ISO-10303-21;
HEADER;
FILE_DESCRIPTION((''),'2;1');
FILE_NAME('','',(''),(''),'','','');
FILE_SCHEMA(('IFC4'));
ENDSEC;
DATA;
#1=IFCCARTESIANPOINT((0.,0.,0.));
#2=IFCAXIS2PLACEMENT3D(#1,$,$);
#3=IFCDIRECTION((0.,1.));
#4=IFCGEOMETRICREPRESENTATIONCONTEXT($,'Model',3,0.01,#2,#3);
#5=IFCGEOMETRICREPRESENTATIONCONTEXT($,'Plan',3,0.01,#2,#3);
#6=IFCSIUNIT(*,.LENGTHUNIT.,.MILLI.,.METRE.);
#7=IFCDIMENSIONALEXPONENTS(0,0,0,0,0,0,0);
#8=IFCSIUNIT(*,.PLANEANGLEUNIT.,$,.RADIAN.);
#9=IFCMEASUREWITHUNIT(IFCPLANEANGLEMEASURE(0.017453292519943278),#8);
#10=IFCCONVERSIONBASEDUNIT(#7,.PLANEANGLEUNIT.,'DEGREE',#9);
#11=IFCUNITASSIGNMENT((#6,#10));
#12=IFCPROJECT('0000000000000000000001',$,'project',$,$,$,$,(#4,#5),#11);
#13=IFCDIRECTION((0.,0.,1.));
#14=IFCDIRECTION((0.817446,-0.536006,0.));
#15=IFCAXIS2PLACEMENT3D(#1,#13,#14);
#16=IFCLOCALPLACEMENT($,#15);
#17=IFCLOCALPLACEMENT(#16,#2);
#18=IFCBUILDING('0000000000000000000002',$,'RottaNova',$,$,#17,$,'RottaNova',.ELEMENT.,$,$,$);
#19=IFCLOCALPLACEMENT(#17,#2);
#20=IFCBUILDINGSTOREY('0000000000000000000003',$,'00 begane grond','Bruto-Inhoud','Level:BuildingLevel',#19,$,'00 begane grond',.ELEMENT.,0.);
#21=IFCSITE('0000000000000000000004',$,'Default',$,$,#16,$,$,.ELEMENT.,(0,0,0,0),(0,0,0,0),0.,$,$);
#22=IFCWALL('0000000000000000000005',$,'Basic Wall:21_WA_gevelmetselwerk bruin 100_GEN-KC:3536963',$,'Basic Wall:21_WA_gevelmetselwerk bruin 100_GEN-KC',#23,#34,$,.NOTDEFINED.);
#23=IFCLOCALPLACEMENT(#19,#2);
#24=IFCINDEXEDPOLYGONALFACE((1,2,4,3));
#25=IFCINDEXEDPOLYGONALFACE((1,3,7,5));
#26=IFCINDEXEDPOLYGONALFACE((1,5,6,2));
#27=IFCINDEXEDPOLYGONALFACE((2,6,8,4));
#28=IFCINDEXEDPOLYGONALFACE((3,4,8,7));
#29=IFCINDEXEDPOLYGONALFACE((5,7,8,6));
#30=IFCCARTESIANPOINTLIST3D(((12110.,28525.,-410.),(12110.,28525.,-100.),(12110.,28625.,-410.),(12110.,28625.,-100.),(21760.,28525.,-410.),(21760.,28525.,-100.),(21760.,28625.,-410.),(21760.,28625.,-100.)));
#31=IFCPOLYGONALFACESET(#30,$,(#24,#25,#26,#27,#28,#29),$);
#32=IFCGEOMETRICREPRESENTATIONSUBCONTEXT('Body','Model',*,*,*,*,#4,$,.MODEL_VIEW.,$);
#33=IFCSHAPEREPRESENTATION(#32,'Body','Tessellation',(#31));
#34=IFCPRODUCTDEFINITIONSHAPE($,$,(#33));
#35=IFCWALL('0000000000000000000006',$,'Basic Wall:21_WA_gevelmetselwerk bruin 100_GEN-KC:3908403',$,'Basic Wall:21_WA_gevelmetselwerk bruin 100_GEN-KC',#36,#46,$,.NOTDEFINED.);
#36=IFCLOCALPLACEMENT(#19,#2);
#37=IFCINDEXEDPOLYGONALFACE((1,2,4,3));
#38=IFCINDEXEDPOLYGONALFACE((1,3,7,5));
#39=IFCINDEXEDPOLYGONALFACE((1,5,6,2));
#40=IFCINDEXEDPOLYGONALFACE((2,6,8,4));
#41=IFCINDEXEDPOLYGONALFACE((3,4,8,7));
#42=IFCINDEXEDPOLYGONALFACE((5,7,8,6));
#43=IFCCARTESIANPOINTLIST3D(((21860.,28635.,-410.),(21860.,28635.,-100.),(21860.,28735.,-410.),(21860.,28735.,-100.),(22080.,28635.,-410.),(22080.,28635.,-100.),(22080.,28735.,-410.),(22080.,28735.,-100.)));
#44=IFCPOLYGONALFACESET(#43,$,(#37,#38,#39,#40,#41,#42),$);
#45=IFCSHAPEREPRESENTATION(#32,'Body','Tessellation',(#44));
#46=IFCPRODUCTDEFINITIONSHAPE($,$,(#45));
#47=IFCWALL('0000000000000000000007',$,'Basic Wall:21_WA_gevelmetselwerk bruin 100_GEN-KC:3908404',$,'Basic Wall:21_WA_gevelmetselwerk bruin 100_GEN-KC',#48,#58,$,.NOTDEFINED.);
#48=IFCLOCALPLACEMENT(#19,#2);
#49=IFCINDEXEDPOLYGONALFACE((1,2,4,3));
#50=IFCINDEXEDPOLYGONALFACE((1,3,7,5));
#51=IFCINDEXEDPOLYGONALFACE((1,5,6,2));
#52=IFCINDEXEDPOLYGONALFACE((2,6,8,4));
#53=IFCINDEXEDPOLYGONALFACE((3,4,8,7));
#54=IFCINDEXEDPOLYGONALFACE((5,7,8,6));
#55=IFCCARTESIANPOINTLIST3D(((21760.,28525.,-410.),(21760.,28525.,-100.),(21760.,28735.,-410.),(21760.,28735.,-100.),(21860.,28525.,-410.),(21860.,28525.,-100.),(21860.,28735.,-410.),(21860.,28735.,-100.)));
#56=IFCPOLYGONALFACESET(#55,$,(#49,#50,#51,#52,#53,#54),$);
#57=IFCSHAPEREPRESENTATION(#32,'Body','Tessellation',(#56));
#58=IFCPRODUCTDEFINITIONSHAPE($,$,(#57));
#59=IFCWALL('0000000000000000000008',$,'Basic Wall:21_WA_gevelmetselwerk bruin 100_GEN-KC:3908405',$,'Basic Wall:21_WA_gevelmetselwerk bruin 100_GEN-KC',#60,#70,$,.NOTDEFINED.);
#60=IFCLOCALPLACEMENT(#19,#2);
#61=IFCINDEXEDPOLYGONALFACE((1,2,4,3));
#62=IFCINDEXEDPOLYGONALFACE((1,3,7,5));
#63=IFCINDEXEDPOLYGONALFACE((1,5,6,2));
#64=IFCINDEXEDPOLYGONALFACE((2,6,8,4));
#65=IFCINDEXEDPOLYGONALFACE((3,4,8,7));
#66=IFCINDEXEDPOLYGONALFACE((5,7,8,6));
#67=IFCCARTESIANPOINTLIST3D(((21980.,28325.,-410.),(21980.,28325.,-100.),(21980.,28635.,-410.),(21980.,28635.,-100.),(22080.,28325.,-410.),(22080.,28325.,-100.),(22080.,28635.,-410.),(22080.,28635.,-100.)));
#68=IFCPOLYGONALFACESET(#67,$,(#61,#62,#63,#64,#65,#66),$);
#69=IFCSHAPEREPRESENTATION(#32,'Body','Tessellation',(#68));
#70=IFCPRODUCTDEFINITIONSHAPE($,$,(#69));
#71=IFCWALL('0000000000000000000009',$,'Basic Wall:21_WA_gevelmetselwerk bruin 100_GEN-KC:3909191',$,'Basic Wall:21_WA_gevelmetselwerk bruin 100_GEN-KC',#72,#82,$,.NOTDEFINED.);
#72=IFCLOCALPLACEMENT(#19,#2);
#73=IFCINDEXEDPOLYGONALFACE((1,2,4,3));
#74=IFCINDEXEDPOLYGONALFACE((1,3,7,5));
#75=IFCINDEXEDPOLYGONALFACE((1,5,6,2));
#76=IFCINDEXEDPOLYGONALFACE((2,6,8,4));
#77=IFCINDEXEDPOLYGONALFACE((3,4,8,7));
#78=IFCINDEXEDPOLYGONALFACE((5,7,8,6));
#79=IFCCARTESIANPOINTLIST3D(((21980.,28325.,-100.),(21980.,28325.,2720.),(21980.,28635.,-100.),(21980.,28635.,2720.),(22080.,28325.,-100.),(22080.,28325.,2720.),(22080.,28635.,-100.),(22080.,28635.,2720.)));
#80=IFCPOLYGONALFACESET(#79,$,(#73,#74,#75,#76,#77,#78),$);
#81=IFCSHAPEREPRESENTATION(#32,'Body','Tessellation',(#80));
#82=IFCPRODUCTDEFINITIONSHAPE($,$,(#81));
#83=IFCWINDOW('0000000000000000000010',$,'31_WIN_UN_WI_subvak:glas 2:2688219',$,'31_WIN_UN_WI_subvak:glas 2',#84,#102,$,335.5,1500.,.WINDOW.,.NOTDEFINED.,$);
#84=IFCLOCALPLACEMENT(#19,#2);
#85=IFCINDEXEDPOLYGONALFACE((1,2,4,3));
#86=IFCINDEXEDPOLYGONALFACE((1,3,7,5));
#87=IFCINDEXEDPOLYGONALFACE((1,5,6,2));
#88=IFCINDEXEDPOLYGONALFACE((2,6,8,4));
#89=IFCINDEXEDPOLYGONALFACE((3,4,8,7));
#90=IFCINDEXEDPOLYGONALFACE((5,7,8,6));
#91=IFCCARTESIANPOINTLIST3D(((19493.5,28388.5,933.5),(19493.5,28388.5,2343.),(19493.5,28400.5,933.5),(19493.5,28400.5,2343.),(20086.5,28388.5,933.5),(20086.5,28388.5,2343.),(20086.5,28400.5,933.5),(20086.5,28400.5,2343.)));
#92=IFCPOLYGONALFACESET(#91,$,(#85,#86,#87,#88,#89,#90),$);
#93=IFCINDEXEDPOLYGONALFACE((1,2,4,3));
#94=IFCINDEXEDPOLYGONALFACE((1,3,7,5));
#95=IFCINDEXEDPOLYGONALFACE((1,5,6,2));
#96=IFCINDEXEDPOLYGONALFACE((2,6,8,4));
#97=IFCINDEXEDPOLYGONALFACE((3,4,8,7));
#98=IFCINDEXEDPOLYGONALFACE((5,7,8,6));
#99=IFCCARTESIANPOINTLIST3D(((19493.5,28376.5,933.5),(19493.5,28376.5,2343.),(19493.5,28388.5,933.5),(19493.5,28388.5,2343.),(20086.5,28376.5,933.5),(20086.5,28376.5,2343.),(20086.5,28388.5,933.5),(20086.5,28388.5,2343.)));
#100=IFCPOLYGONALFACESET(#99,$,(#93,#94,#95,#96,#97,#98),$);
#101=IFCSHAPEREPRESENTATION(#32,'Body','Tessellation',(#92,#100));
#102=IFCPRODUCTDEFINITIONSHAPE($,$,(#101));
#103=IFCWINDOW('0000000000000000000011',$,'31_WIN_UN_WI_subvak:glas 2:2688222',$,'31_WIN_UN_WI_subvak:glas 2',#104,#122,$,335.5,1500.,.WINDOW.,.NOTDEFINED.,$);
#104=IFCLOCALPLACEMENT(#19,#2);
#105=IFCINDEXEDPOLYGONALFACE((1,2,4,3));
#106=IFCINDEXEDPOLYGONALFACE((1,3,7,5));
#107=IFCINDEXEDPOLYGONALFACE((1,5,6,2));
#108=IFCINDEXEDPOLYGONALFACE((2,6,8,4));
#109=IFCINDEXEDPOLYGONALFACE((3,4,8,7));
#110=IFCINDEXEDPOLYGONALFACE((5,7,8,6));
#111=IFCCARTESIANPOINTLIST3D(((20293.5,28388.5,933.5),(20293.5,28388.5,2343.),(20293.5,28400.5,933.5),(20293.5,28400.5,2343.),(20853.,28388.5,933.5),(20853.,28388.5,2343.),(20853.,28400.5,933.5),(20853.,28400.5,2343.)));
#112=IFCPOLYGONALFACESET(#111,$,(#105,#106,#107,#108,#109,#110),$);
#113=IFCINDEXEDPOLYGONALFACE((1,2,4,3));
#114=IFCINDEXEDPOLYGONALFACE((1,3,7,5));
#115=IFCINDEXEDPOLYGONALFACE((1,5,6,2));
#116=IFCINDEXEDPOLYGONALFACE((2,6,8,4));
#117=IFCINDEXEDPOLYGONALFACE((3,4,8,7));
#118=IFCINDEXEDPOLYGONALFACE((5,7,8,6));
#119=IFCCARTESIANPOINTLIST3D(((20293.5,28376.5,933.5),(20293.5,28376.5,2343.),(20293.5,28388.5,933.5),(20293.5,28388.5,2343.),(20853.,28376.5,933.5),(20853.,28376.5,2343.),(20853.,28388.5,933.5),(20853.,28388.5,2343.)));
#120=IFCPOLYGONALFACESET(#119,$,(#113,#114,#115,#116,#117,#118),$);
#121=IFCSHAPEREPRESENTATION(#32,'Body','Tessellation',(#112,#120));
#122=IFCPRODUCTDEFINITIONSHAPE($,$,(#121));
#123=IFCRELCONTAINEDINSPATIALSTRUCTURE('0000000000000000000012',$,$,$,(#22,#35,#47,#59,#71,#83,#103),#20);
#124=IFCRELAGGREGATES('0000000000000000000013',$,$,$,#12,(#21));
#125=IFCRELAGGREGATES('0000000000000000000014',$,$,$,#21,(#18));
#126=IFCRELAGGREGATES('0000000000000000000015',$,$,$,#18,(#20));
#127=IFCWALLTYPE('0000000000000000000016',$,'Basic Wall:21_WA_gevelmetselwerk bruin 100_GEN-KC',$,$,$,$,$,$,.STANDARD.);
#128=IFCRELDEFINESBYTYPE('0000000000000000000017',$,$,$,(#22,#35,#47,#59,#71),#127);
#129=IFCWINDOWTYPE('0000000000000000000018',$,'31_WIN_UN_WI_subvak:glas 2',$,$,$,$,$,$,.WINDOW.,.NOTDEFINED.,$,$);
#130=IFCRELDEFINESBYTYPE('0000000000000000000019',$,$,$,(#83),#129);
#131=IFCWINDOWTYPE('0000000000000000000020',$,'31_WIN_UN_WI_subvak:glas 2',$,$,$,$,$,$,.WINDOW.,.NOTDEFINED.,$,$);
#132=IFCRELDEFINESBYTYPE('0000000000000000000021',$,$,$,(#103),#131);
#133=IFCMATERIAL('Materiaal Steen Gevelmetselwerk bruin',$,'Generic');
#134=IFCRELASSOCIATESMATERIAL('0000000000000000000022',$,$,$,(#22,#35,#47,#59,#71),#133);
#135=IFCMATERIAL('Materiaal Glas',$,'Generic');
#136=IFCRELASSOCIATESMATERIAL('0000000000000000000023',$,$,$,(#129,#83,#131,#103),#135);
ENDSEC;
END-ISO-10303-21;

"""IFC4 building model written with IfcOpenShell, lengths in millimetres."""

from ifc_helpers import new_model, entity, si_unit, converted_unit, direction, frame, origin, place, context, subcontext, project, spatial, indexed_curve, outline, extrude, source, transform, mapped, material, type_object, type_shapes, element, save


model = new_model("IFC4")

# Units and contexts
model_context = context("Model", 3, precision=0.01, world=origin(), true_north=direction((0.0, 1.0)))
plan_context = context("Plan", 3, precision=0.01, world=origin(), true_north=direction((0.0, 1.0)))
body_context = subcontext(model_context, "Body", "Model", "MODEL_VIEW")
ifc_project = project(units=[si_unit("LENGTHUNIT", "METRE", prefix="MILLI"), converted_unit("PLANEANGLEUNIT", "DEGREE", entity("IfcPlaneAngleMeasure", 0.017453292519943278), si_unit("PLANEANGLEUNIT", "RADIAN"), dimensions=[0, 0, 0, 0, 0, 0, 0])], contexts=[model_context, plan_context])

# Site, building, storey
site_placement = place(None, frame((0.0, 0.0, 0.0), z_axis=(0.0, 0.0, 1.0), x_axis=(0.817446, -0.536006, 0.0)))
site = spatial("IfcSite", under=ifc_project, at=site_placement, Name="Default", CompositionType="ELEMENT", RefLatitude=(0, 0, 0, 0), RefLongitude=(0, 0, 0, 0), RefElevation=0.0)
building_placement = place(site_placement, origin())
building = spatial("IfcBuilding", under=site, at=building_placement, Name="RottaNova", LongName="RottaNova", CompositionType="ELEMENT")
storey_placement = place(building_placement, origin())
storey = spatial("IfcBuildingStorey", under=building, at=storey_placement, Name="00 begane grond", Description="Bruto-Inhoud", ObjectType="Level:BuildingLevel", LongName="00 begane grond", CompositionType="ELEMENT", Elevation=0.0)

# Shared definitions
ifc_material_1 = material(Name="Materiaal Glas", Category="Generic")

# Walls
ifc_material_2 = material(Name="Materiaal Steen Gevelmetselwerk bruin", Category="Generic")
wall_type_1 = type_object("IfcWallType", Name="Basic Wall:21_WA_gevelmetselwerk bruin 100_GEN-KC", PredefinedType="STANDARD")
wall_1_placement = place(storey_placement, frame((21760.0, 28575.0, -410.0), z_axis=(0.0, 0.0, 1.0), x_axis=(-1.0, 0.0, 0.0)))
element("IfcWall", 1, at=wall_1_placement, inside=storey, type_object=wall_type_1, material=ifc_material_2, Name="Basic Wall:21_WA_gevelmetselwerk bruin 100_GEN-KC:3536963", ObjectType="Basic Wall:21_WA_gevelmetselwerk bruin 100_GEN-KC", PredefinedType="NOTDEFINED", context=body_context, shape_type="SweptSolid", body=[
    extrude(outline(indexed_curve([(9650.0, 50.0), (0.0, 50.0), (0.0, -50.0), (9650.0, -50.0), (9650.0, 50.0)], self_intersect=False)), origin(), (0.0, 0.0, 1.0), 310.0),
])
wall_2_placement = place(storey_placement, frame((22080.0, 28685.0, -410.0), z_axis=(0.0, 0.0, 1.0), x_axis=(-1.0, 0.0, 0.0)))
element("IfcWall", 2, at=wall_2_placement, inside=storey, type_object=wall_type_1, material=ifc_material_2, Name="Basic Wall:21_WA_gevelmetselwerk bruin 100_GEN-KC:3908403", ObjectType="Basic Wall:21_WA_gevelmetselwerk bruin 100_GEN-KC", PredefinedType="NOTDEFINED", context=body_context, shape_type="SweptSolid", body=[
    extrude(outline(indexed_curve([(220.0, 50.0), (0.0, 50.0), (0.0, -50.0), (220.0, -50.0), (220.0, 50.0)], self_intersect=False)), origin(), (0.0, 0.0, 1.0), 310.0),
])
wall_3_placement = place(storey_placement, frame((21810.0, 28735.0, -410.0), z_axis=(0.0, 0.0, 1.0), x_axis=(0.0, -1.0, 0.0)))
element("IfcWall", 3, at=wall_3_placement, inside=storey, type_object=wall_type_1, material=ifc_material_2, Name="Basic Wall:21_WA_gevelmetselwerk bruin 100_GEN-KC:3908404", ObjectType="Basic Wall:21_WA_gevelmetselwerk bruin 100_GEN-KC", PredefinedType="NOTDEFINED", context=body_context, shape_type="SweptSolid", body=[
    extrude(outline(indexed_curve([(210.0, 50.0), (0.0, 50.0), (0.0, -50.0), (210.0, -50.0), (210.0, 50.0)], self_intersect=False)), origin(), (0.0, 0.0, 1.0), 310.0),
])
wall_4_placement = place(storey_placement, frame((22030.0, 28325.0, -410.0), z_axis=(0.0, 0.0, 1.0), x_axis=(0.0, 1.0, 0.0)))
element("IfcWall", 4, at=wall_4_placement, inside=storey, type_object=wall_type_1, material=ifc_material_2, Name="Basic Wall:21_WA_gevelmetselwerk bruin 100_GEN-KC:3908405", ObjectType="Basic Wall:21_WA_gevelmetselwerk bruin 100_GEN-KC", PredefinedType="NOTDEFINED", context=body_context, shape_type="SweptSolid", body=[
    extrude(outline(indexed_curve([(310.0, 50.0), (0.0, 50.0), (0.0, -50.0), (310.0, -50.0), (310.0, 50.0)], self_intersect=False)), origin(), (0.0, 0.0, 1.0), 310.0),
])
wall_5_placement = place(storey_placement, frame((22030.0, 28325.0, -100.0), z_axis=(0.0, 0.0, 1.0), x_axis=(0.0, 1.0, 0.0)))
element("IfcWall", 5, at=wall_5_placement, inside=storey, type_object=wall_type_1, material=ifc_material_2, Name="Basic Wall:21_WA_gevelmetselwerk bruin 100_GEN-KC:3909191", ObjectType="Basic Wall:21_WA_gevelmetselwerk bruin 100_GEN-KC", PredefinedType="NOTDEFINED", context=body_context, shape_type="SweptSolid", body=[
    extrude(outline(indexed_curve([(310.0, 50.0), (0.0, 50.0), (0.0, -50.0), (310.0, -50.0), (310.0, 50.0)], self_intersect=False)), origin(), (0.0, 0.0, 1.0), 2820.0),
])

# Windows
window_type_1 = type_object("IfcWindowType", Name="31_WIN_UN_WI_subvak:glas 2", PartitioningType="NOTDEFINED", PredefinedType="WINDOW", material=ifc_material_1)
shared_shape_1 = source(origin(), body_context, "Body", "SweptSolid", [
    extrude(outline(indexed_curve([(-6.0, -296.5), (6.0, -296.5), (6.0, 296.5), (-6.0, 296.5), (-6.0, -296.5)], self_intersect=False)), frame((0.0, 6.0, 0.0), z_axis=(0.0, 0.0, 1.0), x_axis=(0.0, -1.0, 0.0)), (0.0, 0.0, 1.0), 1409.5),
    extrude(outline(indexed_curve([(-6.0, -296.5), (6.0, -296.5), (6.0, 296.5), (-6.0, 296.5), (-6.0, -296.5)], self_intersect=False)), frame((0.0, -6.0, 0.0), z_axis=(0.0, 0.0, 1.0), x_axis=(0.0, -1.0, 0.0)), (0.0, 0.0, 1.0), 1409.5),
])
type_shapes(window_type_1, [shared_shape_1])
window_1_placement = place(storey_placement, frame((19790.0, 28388.5, 933.5)))
element("IfcWindow", 6, at=window_1_placement, inside=storey, type_object=window_type_1, material=ifc_material_1, Name="31_WIN_UN_WI_subvak:glas 2:2688219", ObjectType="31_WIN_UN_WI_subvak:glas 2", OverallHeight=335.5, OverallWidth=1500.0, PartitioningType="NOTDEFINED", PredefinedType="WINDOW", context=body_context, shape_type="MappedRepresentation", body=[
    mapped(shared_shape_1, transform((0.0, 0.0, 0.0), scale=1.0)),
])
window_type_2 = type_object("IfcWindowType", Name="31_WIN_UN_WI_subvak:glas 2", PartitioningType="NOTDEFINED", PredefinedType="WINDOW", material=ifc_material_1)
shared_shape_2 = source(origin(), body_context, "Body", "SweptSolid", [
    extrude(outline(indexed_curve([(-6.0, -279.8), (6.0, -279.8), (6.0, 279.8), (-6.0, 279.8), (-6.0, -279.8)], self_intersect=False)), frame((0.0, 6.0, 0.0), z_axis=(0.0, 0.0, 1.0), x_axis=(0.0, -1.0, 0.0)), (0.0, 0.0, 1.0), 1409.5),
    extrude(outline(indexed_curve([(-6.0, -279.8), (6.0, -279.8), (6.0, 279.8), (-6.0, 279.8), (-6.0, -279.8)], self_intersect=False)), frame((0.0, -6.0, 0.0), z_axis=(0.0, 0.0, 1.0), x_axis=(0.0, -1.0, 0.0)), (0.0, 0.0, 1.0), 1409.5),
])
type_shapes(window_type_2, [shared_shape_2])
window_2_placement = place(storey_placement, frame((20573.3, 28388.5, 933.5)))
element("IfcWindow", 7, at=window_2_placement, inside=storey, type_object=window_type_2, material=ifc_material_1, Name="31_WIN_UN_WI_subvak:glas 2:2688222", ObjectType="31_WIN_UN_WI_subvak:glas 2", OverallHeight=335.5, OverallWidth=1500.0, PartitioningType="NOTDEFINED", PredefinedType="WINDOW", context=body_context, shape_type="MappedRepresentation", body=[
    mapped(shared_shape_2, transform((0.0, 0.0, 0.0), scale=1.0)),
])

save(model, "model.ifc")
